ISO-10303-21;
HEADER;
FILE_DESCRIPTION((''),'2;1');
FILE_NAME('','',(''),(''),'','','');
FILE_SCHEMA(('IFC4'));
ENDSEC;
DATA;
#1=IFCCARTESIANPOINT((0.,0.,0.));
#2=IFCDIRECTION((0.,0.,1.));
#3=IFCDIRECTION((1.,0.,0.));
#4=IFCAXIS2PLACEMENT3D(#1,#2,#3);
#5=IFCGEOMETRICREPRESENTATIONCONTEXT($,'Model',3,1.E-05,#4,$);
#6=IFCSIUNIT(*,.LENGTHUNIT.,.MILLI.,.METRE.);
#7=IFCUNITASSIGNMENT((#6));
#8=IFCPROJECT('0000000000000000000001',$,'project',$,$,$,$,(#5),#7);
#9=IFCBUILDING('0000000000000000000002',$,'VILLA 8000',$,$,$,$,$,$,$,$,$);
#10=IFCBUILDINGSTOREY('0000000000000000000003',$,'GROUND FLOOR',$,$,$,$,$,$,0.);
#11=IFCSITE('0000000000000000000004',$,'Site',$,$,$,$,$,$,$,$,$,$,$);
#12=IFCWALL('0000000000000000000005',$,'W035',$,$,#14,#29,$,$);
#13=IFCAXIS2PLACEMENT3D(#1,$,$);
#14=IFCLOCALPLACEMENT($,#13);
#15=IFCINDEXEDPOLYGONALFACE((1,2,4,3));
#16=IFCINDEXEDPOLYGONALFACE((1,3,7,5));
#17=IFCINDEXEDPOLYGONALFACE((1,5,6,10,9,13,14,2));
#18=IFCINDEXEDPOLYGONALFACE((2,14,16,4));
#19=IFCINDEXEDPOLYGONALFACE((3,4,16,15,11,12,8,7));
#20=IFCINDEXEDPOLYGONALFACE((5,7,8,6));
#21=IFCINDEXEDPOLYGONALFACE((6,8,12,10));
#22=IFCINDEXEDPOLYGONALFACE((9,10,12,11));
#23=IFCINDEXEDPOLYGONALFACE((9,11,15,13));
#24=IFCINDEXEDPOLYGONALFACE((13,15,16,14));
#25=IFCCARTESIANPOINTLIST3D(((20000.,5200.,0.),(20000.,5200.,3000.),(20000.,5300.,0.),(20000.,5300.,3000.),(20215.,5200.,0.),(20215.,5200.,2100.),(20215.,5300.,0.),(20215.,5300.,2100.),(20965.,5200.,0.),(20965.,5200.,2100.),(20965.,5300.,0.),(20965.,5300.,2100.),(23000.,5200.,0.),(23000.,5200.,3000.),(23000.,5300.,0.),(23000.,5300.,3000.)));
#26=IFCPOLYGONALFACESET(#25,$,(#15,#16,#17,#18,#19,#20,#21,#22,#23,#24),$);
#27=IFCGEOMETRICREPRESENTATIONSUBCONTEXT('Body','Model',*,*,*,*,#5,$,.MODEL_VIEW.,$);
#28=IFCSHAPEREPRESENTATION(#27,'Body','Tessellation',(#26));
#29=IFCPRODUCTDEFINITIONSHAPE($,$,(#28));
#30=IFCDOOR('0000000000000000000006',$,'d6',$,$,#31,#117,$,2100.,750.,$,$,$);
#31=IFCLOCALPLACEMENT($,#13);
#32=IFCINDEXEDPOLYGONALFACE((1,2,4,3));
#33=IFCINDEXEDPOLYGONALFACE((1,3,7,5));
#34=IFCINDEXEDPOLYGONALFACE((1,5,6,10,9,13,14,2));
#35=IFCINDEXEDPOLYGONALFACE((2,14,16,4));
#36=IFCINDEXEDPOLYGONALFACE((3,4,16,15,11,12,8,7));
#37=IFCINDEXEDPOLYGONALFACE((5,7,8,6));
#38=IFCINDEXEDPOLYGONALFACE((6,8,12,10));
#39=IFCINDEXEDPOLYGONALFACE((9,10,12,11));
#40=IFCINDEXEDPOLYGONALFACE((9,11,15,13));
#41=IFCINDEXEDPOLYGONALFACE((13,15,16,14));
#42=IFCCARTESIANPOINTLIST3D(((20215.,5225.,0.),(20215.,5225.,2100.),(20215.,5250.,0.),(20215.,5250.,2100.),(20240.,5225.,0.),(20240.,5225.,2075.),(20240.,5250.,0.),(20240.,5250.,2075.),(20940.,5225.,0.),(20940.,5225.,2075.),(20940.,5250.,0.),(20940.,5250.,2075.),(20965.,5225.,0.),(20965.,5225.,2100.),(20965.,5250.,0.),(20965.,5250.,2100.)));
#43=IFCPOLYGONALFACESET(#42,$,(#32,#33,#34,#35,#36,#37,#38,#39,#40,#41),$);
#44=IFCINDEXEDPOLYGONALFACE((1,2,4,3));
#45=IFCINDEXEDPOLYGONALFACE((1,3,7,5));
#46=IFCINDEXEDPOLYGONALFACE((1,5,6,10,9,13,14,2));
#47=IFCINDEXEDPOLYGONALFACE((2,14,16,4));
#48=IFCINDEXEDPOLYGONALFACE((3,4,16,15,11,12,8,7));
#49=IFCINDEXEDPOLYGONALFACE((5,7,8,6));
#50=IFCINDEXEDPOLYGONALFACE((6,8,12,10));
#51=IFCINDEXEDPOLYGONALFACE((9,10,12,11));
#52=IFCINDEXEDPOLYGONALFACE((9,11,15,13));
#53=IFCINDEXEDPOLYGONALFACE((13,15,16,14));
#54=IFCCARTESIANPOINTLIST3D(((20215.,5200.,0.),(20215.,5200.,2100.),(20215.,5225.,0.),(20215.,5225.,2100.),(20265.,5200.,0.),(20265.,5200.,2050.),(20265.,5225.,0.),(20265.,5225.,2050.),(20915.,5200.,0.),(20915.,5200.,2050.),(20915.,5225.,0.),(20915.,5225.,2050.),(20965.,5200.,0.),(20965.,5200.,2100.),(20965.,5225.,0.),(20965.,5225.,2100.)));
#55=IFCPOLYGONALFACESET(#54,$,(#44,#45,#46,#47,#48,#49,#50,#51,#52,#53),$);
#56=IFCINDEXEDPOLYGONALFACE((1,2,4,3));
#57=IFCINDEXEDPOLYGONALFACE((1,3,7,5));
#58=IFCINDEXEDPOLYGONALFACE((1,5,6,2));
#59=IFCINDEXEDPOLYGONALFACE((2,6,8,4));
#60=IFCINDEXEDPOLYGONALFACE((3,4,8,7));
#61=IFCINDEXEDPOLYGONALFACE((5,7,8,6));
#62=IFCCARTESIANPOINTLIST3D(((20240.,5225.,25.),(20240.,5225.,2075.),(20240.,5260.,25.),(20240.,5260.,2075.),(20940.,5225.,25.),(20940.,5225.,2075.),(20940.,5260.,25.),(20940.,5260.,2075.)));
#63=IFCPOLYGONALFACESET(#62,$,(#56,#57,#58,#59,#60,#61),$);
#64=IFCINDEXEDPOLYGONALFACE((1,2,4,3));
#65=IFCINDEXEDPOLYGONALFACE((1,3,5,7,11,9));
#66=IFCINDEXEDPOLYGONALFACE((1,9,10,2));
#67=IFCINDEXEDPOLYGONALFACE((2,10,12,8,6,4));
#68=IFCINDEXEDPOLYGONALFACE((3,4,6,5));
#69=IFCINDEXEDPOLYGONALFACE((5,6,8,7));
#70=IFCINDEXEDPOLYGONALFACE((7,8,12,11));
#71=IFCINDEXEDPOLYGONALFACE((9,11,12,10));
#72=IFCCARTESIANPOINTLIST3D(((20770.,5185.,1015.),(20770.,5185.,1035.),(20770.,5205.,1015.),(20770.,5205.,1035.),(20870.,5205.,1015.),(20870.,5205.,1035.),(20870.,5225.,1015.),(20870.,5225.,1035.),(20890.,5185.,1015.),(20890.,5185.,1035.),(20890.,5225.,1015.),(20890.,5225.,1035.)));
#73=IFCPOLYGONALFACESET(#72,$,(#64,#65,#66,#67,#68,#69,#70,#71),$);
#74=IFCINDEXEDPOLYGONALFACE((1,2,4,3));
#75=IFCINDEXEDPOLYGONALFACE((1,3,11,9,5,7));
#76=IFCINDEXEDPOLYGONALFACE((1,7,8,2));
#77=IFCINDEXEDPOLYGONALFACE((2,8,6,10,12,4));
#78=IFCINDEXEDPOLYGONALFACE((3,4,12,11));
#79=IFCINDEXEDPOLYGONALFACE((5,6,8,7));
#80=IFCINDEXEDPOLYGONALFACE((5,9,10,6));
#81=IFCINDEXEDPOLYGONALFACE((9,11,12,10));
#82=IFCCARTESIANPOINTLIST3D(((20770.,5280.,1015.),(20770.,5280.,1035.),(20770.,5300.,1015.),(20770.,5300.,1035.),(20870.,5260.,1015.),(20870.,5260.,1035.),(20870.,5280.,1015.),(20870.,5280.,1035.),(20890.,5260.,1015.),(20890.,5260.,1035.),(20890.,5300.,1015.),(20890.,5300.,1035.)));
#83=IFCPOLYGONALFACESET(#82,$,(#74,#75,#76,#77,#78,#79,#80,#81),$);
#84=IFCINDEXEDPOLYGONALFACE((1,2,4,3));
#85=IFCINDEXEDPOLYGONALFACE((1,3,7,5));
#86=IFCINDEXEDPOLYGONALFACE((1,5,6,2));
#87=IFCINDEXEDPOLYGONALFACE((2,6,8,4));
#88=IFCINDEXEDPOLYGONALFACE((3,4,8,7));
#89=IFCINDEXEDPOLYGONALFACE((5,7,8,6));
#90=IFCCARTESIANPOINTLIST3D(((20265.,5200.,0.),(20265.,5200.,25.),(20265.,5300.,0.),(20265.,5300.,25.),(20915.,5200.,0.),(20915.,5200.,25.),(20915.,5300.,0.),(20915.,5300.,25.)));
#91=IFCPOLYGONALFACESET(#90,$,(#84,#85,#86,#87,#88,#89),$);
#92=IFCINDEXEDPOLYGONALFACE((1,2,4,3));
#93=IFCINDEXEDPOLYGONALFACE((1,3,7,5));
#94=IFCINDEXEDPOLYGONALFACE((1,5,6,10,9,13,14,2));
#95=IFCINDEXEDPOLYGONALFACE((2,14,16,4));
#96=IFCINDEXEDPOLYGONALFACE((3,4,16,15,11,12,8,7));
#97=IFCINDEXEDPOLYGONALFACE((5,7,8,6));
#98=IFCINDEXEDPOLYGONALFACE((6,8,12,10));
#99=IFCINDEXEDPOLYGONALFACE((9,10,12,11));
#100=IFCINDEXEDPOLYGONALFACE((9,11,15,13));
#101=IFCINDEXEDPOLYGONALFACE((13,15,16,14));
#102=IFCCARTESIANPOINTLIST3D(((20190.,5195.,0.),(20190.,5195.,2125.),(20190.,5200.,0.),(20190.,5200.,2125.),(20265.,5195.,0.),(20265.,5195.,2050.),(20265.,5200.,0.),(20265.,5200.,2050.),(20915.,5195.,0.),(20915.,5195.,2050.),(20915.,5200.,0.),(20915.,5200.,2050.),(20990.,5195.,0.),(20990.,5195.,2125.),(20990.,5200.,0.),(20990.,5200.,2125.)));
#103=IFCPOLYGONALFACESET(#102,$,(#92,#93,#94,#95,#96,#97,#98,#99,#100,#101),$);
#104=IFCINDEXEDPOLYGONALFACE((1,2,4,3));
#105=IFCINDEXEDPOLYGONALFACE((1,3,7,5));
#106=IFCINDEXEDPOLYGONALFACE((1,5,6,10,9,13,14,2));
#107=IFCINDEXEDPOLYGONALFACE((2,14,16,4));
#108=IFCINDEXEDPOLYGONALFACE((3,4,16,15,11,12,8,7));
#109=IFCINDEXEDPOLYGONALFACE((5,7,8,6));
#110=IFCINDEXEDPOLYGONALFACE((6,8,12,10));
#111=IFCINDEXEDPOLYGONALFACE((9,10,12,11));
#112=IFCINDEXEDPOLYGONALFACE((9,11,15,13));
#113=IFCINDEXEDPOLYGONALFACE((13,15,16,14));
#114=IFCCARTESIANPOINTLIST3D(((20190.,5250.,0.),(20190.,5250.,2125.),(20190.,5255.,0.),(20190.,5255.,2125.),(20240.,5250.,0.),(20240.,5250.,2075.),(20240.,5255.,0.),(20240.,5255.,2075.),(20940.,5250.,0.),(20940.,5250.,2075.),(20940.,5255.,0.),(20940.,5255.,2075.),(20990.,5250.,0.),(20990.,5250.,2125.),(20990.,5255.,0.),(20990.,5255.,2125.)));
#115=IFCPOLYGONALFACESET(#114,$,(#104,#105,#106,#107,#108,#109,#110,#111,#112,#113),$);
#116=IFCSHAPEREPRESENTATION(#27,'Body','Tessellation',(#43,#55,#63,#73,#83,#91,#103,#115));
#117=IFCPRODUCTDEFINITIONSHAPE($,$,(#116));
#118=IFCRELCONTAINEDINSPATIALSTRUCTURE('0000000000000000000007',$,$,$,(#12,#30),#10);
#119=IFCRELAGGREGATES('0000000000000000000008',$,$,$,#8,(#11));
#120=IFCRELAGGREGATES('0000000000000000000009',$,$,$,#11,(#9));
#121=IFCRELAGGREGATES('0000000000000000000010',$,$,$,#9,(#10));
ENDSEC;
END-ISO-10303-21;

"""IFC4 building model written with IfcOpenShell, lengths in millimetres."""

from ifc_helpers import new_model, si_unit, frame, origin_with_axes, place, context, subcontext, project, spatial, line, indexed_curve, outline, extrude, element, fill, save


model = new_model("IFC4")

# Units and contexts
model_context = context("Model", 3, precision=1e-05, world=origin_with_axes())
body_context = subcontext(model_context, "Body", "Model", "MODEL_VIEW")
ifc_project = project(units=[si_unit("LENGTHUNIT", "METRE", prefix="MILLI")], contexts=[model_context])

# Site, building, storey
site = spatial("IfcSite", under=ifc_project, Name="Site")
building = spatial("IfcBuilding", under=site, Name="VILLA 8000")
storey = spatial("IfcBuildingStorey", under=building, Name="GROUND FLOOR", Elevation=0.0)

# Wall, opening, door
wall_1_placement = place(None, frame((20000.0, 5250.0, 0.0), z_axis=(0.0, 0.0, 1.0), x_axis=(1.0, 0.0, 0.0)))
wall_1 = element("IfcWall", 1, at=wall_1_placement, inside=storey, Name="W035", context=body_context, shape_type="SweptSolid", body=[
    extrude(outline(indexed_curve([(0.0, 0.0), (0.0, 100.0), (3000.0, 100.0), (3000.0, 0.0), (0.0, 0.0)], self_intersect=False)), frame((0.0, -50.0, 0.0), z_axis=(0.0, 0.0, 1.0), x_axis=(1.0, 0.0, 0.0)), (0.0, 0.0, 1.0), 3000.0),
])
opening_1_placement = place(wall_1_placement, frame((215.0, 0.0, 0.0), z_axis=(0.0, 0.0, 1.0), x_axis=(1.0, 0.0, 0.0)))
opening_1 = element("IfcOpeningElement", 2, at=opening_1_placement, cuts=wall_1, context=body_context, shape_type="SweptSolid", body=[
    extrude(outline(indexed_curve([(0.0, 0.0), (0.0, 200.0), (750.0, 200.0), (750.0, 0.0), (0.0, 0.0)], self_intersect=False)), frame((0.0, -100.0, 0.0), z_axis=(0.0, 0.0, 1.0), x_axis=(1.0, 0.0, 0.0)), (0.0, 0.0, 1.0), 2100.0),
])
door_1_placement = place(None, frame((20215.0, 5200.0, 0.0), z_axis=(0.0, 0.0, 1.0), x_axis=(1.0, 0.0, 0.0)))
door_1 = element("IfcDoor", 3, at=door_1_placement, inside=storey, Name="d6", OverallHeight=2100.0, OverallWidth=750.0, context=body_context, shape_type="SweptSolid", body=[
    extrude(outline(indexed_curve([(0.0, 0.0), (0.0, 2100.0), (750.0, 2100.0), (750.0, 0.0), (725.0, 0.0), (725.0, 2075.0), (25.0, 2075.0), (25.0, 0.0)], segments=[line(1, 2, 3, 4, 5, 6, 7, 8, 1)])), frame((0.0, 25.0, 0.0), z_axis=(0.0, -1.0, 0.0), x_axis=(1.0, 0.0, 0.0)), (0.0, 0.0, -1.0), 25.0),
    extrude(outline(indexed_curve([(0.0, 0.0), (0.0, 2100.0), (750.0, 2100.0), (750.0, 0.0), (700.0, 0.0), (700.0, 2050.0), (50.0, 2050.0), (50.0, 0.0)], segments=[line(1, 2, 3, 4, 5, 6, 7, 8, 1)])), frame((0.0, 0.0, 0.0), z_axis=(0.0, -1.0, 0.0), x_axis=(1.0, 0.0, 0.0)), (0.0, 0.0, -1.0), 25.0),
    extrude(outline(indexed_curve([(0.0, 0.0), (700.0, 0.0), (700.0, 35.0), (0.0, 35.0)], segments=[line(1, 2, 3, 4, 1)])), frame((25.0, 25.0, 25.0), z_axis=(0.0, 0.0, 1.0), x_axis=(1.0, 0.0, 0.0)), (0.0, 0.0, 1.0), 2050.0),
    extrude(outline(indexed_curve([(0.0, 0.0), (0.0, -40.0), (-120.0, -40.0), (-120.0, -20.0), (-20.0, -20.0), (-20.0, 0.0)], segments=[line(1, 2, 3, 4, 5, 6, 1)])), frame((675.0, 25.0, 1015.0), z_axis=(0.0, 0.0, 1.0), x_axis=(1.0, 0.0, 0.0)), (0.0, 0.0, 1.0), 20.0),
    extrude(outline(indexed_curve([(0.0, 0.0), (0.0, 40.0), (-120.0, 40.0), (-120.0, 20.0), (-20.0, 20.0), (-20.0, 0.0)], segments=[line(1, 2, 3, 4, 5, 6, 1)])), frame((675.0, 60.0, 1015.0), z_axis=(0.0, 0.0, 1.0), x_axis=(1.0, 0.0, 0.0)), (0.0, 0.0, 1.0), 20.0),
    extrude(outline(indexed_curve([(0.0, 0.0), (650.0, 0.0), (650.0, 100.0), (0.0, 100.0)], segments=[line(1, 2, 3, 4, 1)])), frame((50.0, 0.0, 0.0), z_axis=(0.0, 0.0, 1.0), x_axis=(1.0, 0.0, 0.0)), (0.0, 0.0, 1.0), 25.0),
    extrude(outline(indexed_curve([(0.0, 0.0), (0.0, 2125.0), (800.0, 2125.0), (800.0, 0.0), (725.0, 0.0), (725.0, 2050.0), (75.0, 2050.0), (75.0, 0.0)], segments=[line(1, 2, 3, 4, 5, 6, 7, 8, 1)])), frame((-25.0, -5.0, 0.0), z_axis=(0.0, -1.0, 0.0), x_axis=(1.0, 0.0, 0.0)), (0.0, 0.0, -1.0), 5.0),
    extrude(outline(indexed_curve([(0.0, 0.0), (0.0, 2125.0), (800.0, 2125.0), (800.0, 0.0), (750.0, 0.0), (750.0, 2075.0), (50.0, 2075.0), (50.0, 0.0)], segments=[line(1, 2, 3, 4, 5, 6, 7, 8, 1)])), frame((-25.0, 50.0, 0.0), z_axis=(0.0, -1.0, 0.0), x_axis=(1.0, 0.0, 0.0)), (0.0, 0.0, -1.0), 5.0),
])
fill(opening_1, door_1)

save(model, "model.ifc")
